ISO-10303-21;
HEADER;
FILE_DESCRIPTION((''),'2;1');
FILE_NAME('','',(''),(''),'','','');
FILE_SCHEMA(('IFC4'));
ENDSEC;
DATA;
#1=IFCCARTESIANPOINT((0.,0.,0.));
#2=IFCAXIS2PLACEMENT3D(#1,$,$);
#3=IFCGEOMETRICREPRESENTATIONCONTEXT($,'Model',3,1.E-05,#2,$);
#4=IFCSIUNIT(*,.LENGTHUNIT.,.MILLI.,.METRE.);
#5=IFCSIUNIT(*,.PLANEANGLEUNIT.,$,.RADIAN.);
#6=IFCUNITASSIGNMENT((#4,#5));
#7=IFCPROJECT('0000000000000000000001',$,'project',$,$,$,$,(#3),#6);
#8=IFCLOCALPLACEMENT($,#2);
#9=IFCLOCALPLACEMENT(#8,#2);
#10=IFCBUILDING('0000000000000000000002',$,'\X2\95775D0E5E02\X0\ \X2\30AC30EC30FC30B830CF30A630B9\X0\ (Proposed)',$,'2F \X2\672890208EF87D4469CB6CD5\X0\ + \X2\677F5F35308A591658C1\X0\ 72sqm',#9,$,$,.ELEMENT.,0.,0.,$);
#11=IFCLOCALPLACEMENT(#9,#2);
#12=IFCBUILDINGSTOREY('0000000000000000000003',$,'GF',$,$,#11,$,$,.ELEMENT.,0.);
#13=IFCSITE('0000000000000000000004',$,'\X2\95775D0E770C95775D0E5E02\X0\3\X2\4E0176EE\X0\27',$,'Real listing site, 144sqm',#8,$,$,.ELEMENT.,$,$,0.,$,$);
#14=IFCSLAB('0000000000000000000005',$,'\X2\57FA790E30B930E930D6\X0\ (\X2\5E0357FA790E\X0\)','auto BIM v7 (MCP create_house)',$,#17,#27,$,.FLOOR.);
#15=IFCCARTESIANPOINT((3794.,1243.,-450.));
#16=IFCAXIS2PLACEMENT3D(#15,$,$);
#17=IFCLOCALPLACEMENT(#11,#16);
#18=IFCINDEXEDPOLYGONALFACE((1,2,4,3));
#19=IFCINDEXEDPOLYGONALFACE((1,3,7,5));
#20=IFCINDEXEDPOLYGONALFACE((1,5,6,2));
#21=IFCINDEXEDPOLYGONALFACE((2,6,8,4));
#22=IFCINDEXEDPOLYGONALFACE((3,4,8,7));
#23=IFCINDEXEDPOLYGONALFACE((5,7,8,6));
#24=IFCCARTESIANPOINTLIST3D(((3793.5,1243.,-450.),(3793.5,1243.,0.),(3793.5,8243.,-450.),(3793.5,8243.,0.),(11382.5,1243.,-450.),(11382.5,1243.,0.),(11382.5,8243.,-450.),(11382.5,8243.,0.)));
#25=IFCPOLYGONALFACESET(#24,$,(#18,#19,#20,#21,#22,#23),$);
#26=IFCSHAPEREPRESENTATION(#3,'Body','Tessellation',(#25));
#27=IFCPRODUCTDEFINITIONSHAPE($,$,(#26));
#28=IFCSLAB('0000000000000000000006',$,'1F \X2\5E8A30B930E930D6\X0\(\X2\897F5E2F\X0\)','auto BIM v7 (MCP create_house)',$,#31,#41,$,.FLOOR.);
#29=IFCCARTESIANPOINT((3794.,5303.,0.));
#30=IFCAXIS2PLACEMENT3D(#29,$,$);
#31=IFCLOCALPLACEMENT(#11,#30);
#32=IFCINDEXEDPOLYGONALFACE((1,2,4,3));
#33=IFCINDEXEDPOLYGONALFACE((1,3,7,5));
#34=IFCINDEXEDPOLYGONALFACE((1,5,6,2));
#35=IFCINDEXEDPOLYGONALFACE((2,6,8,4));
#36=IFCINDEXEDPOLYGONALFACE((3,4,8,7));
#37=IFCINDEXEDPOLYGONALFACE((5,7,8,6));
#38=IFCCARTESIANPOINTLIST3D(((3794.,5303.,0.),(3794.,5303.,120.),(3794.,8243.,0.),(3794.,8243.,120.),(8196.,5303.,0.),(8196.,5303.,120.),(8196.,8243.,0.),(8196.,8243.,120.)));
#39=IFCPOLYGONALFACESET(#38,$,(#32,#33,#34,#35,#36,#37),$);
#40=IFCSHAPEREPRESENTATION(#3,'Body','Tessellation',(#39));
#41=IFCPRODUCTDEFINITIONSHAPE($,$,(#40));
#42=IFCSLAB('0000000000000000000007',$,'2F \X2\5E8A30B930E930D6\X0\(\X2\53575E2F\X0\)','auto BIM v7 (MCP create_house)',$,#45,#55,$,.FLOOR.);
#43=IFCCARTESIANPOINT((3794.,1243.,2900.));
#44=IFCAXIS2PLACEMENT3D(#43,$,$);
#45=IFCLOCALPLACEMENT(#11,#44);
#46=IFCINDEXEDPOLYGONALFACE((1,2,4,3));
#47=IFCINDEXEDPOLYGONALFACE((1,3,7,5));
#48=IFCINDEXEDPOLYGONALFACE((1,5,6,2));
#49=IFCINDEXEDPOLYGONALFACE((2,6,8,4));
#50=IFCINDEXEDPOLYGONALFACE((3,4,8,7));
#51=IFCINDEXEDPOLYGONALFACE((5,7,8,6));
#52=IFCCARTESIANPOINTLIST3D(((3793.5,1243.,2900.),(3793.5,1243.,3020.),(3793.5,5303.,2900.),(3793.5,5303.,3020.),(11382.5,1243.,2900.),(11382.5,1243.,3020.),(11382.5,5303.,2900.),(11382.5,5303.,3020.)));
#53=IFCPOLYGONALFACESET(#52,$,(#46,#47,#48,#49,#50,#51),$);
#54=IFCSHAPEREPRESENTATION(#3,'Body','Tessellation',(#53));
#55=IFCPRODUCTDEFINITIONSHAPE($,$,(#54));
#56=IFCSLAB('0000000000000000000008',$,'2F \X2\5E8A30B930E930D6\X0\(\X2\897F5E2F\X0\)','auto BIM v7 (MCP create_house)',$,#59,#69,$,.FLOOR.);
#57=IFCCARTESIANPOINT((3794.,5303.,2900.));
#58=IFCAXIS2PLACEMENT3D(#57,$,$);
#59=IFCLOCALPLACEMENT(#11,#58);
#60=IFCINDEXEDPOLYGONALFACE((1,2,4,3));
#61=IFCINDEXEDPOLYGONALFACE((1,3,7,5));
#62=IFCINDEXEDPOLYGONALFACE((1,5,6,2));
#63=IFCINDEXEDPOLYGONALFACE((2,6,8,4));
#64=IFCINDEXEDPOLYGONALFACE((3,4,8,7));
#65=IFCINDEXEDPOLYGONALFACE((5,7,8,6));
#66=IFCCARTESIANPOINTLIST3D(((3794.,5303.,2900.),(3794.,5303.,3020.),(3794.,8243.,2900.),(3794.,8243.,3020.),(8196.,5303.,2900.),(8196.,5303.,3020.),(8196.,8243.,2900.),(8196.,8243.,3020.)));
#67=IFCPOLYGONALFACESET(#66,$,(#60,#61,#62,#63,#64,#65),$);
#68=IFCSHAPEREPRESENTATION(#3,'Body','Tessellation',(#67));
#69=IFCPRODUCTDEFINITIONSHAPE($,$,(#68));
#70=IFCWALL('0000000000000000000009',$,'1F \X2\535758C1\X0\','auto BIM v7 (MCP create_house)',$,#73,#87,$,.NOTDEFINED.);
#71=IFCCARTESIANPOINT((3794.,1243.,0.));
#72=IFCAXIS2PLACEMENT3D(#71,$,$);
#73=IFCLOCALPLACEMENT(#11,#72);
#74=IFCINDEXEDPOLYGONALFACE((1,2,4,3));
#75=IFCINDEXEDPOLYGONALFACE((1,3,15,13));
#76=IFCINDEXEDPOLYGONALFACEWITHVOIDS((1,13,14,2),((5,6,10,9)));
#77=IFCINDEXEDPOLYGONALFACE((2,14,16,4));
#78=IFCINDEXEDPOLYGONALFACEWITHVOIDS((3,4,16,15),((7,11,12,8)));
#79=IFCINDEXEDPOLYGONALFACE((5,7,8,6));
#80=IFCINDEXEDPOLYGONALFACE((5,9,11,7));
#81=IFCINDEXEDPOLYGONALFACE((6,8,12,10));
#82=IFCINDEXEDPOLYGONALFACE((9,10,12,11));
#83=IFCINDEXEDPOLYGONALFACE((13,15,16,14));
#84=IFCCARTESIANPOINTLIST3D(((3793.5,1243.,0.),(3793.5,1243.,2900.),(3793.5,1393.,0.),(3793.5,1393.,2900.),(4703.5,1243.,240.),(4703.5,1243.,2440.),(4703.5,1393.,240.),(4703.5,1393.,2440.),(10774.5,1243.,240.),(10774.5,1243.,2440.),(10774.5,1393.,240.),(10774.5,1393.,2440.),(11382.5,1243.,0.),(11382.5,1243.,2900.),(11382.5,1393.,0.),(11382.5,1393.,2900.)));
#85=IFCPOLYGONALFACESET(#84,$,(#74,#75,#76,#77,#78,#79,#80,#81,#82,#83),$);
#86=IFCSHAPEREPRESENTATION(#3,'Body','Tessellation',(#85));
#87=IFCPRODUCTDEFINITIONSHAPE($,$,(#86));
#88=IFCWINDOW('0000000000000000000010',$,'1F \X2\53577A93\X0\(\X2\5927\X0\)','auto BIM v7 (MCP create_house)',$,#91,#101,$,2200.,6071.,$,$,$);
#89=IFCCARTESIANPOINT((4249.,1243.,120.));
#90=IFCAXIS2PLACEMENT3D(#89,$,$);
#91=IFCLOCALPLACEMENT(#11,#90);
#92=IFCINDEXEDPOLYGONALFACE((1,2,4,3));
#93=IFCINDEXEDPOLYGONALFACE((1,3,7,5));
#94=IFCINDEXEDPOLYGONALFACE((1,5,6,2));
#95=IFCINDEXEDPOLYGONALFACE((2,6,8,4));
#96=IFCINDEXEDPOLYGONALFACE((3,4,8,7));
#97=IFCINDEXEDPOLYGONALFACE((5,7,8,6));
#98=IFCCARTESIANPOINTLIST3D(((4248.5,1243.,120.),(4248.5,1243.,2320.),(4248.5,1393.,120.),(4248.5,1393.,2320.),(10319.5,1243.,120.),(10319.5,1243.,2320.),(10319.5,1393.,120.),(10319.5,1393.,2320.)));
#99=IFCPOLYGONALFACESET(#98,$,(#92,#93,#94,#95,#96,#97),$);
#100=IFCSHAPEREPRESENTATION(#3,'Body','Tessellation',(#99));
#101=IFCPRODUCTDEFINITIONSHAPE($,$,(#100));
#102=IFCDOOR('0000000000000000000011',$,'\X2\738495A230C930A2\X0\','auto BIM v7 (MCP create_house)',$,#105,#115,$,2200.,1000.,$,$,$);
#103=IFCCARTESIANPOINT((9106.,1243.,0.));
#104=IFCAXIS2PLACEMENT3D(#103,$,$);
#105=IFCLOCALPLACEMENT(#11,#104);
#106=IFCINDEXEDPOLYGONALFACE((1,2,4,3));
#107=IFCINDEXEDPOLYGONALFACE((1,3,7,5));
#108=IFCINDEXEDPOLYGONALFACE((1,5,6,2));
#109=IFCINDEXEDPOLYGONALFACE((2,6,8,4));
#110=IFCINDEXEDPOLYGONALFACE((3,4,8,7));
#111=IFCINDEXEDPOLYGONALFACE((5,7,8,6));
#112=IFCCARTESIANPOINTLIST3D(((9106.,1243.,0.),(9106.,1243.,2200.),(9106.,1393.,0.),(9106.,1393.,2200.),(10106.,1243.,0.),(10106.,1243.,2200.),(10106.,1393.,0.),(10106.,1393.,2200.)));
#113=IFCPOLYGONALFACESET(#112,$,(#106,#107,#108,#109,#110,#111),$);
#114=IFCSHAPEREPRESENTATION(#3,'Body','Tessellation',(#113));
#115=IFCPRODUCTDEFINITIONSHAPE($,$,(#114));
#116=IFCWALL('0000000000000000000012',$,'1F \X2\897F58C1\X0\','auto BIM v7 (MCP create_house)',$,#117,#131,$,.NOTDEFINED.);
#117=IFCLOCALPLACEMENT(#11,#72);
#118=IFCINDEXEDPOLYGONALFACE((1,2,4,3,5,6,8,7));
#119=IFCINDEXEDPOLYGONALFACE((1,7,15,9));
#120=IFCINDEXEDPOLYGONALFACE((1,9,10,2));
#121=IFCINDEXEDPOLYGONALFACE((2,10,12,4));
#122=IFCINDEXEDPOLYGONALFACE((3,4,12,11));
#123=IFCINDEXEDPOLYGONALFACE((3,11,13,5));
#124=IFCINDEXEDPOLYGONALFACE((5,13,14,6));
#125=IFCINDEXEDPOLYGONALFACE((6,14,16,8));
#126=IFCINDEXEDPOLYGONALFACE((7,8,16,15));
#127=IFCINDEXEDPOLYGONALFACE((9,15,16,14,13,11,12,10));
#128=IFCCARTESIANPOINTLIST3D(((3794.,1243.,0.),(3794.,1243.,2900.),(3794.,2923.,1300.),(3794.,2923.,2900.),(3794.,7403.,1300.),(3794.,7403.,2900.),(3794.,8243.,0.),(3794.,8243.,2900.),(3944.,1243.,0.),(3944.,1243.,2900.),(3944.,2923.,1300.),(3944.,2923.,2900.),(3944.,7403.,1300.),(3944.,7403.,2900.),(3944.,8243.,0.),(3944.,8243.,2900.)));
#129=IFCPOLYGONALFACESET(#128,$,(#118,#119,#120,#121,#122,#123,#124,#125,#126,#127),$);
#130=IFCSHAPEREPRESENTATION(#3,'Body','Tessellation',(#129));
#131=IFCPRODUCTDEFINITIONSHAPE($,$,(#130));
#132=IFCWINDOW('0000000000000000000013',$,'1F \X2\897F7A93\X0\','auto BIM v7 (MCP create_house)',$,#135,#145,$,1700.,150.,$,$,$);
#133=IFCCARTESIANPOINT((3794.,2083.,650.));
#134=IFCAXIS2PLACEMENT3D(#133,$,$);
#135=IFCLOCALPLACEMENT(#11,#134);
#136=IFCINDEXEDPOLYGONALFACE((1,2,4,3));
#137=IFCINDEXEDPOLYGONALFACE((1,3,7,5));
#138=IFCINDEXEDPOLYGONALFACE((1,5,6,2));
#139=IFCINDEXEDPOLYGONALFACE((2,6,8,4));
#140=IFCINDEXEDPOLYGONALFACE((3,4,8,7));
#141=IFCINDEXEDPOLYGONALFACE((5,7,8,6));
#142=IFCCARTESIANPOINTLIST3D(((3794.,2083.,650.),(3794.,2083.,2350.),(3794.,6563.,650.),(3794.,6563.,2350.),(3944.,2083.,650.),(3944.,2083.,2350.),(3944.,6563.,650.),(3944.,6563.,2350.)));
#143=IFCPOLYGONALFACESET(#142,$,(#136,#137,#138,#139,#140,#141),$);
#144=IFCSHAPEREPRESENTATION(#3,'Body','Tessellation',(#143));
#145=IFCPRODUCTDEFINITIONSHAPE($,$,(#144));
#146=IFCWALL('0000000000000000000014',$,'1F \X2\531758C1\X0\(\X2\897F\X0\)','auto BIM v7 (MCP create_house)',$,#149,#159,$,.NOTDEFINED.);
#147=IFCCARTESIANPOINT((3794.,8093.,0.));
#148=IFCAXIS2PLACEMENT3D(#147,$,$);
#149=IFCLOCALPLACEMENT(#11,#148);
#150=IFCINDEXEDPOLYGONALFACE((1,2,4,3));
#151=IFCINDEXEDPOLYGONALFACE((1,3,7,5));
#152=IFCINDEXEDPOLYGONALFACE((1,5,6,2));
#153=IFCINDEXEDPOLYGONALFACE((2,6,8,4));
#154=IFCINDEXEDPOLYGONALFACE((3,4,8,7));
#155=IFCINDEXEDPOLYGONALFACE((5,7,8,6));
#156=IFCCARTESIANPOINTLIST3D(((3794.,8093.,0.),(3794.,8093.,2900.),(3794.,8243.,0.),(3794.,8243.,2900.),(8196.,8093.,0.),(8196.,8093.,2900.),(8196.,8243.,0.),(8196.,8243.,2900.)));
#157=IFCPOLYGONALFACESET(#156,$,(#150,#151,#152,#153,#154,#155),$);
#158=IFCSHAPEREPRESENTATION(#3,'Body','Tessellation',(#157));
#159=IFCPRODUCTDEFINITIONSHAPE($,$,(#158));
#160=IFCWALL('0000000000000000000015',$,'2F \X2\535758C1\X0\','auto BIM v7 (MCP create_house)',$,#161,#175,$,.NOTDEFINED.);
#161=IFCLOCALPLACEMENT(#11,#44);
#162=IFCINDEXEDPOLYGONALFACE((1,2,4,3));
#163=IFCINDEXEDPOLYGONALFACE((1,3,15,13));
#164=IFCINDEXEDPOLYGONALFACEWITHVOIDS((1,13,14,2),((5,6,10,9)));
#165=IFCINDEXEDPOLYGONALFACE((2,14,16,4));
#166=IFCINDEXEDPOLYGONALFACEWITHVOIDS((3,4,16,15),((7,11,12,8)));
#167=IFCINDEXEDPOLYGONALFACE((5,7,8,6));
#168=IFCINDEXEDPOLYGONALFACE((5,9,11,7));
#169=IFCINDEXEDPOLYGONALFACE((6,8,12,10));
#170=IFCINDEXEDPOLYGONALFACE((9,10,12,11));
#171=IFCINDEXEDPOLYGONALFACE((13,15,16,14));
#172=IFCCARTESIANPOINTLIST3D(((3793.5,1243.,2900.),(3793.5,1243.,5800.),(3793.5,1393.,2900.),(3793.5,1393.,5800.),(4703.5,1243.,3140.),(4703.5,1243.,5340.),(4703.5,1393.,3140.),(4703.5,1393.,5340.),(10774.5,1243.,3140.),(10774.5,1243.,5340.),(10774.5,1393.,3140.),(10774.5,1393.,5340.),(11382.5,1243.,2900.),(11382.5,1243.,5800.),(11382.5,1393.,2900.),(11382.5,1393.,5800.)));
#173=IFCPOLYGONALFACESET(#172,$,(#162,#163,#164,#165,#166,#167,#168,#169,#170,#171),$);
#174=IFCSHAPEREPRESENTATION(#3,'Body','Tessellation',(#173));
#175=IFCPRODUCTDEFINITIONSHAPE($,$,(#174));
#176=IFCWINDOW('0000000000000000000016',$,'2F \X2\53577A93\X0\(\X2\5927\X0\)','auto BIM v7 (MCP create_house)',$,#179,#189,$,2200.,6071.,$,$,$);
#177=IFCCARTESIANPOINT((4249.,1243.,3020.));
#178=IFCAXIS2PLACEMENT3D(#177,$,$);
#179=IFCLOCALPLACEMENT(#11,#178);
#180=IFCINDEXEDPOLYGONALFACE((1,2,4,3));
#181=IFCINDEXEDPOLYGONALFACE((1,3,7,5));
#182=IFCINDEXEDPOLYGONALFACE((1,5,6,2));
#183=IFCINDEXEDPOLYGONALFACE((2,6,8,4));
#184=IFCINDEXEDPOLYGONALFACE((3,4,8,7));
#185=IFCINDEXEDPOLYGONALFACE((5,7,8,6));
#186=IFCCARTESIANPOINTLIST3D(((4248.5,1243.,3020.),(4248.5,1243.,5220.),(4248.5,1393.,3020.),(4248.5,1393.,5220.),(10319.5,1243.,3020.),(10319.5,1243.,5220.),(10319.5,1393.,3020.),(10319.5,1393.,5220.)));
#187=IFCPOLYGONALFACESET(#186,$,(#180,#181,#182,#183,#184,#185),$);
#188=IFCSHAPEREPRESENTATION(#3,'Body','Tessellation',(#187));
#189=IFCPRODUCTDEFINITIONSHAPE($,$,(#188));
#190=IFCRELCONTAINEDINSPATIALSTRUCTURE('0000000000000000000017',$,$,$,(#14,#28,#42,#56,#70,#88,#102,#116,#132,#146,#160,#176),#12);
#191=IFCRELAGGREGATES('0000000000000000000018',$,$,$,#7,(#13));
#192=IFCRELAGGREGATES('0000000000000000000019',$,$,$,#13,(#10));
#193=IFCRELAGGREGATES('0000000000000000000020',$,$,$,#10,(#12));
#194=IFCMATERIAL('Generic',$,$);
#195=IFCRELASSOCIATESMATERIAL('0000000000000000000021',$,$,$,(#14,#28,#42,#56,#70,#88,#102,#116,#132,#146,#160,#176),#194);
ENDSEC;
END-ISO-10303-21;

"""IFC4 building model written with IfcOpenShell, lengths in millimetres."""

from ifc_helpers import new_model, si_unit, frame, frame_2d, origin, place, context, project, spatial, rectangle, extrude, material, element, fill, save


model = new_model("IFC4")

# Units and contexts
model_context = context("Model", 3, precision=1e-05, world=origin())
ifc_project = project(units=[si_unit("LENGTHUNIT", "METRE", prefix="MILLI"), si_unit("PLANEANGLEUNIT", "RADIAN")], contexts=[model_context])

# Site, building, storey
site_placement = place(None, origin())
site = spatial("IfcSite", under=ifc_project, at=site_placement, Name="長崎県長崎市3丁目27", ObjectType="Real listing site, 144sqm", CompositionType="ELEMENT", RefElevation=0.0)
building_placement = place(site_placement, origin())
building = spatial("IfcBuilding", under=site, at=building_placement, Name="長崎市 ガレージハウス (Proposed)", ObjectType="2F 木造軸組構法 + 板張り外壁 72sqm", CompositionType="ELEMENT", ElevationOfRefHeight=0.0, ElevationOfTerrain=0.0)
storey_placement = place(building_placement, origin())
storey = spatial("IfcBuildingStorey", under=building, at=storey_placement, Name="GF", CompositionType="ELEMENT", Elevation=0.0)

# Slabs
ifc_material = material(Name="Generic")
slab_1_placement = place(storey_placement, frame((3794.0, 1243.0, -450.0)))
element("IfcSlab", 1, at=slab_1_placement, inside=storey, material=ifc_material, Name="基礎スラブ (布基礎)", Description="auto BIM v7 (MCP create_house)", PredefinedType="FLOOR", context=model_context, shape_type="SweptSolid", body=[
    extrude(rectangle(XDim=7589.0, YDim=7000.0, at=frame_2d((3794.0, 3500.0))), frame((3794.0, 1243.0, -450.0)), (0.0, 0.0, 1.0), 450.0),
])
slab_2_placement = place(storey_placement, frame((3794.0, 5303.0, 0.0)))
element("IfcSlab", 2, at=slab_2_placement, inside=storey, material=ifc_material, Name="1F 床スラブ(西帯)", Description="auto BIM v7 (MCP create_house)", PredefinedType="FLOOR", context=model_context, shape_type="SweptSolid", body=[
    extrude(rectangle(XDim=4402.0, YDim=2940.0, at=frame_2d((2201.0, 1470.0))), frame((3794.0, 5303.0, 0.0)), (0.0, 0.0, 1.0), 120.0),
])
slab_3_placement = place(storey_placement, frame((3794.0, 1243.0, 2900.0)))
element("IfcSlab", 3, at=slab_3_placement, inside=storey, material=ifc_material, Name="2F 床スラブ(南帯)", Description="auto BIM v7 (MCP create_house)", PredefinedType="FLOOR", context=model_context, shape_type="SweptSolid", body=[
    extrude(rectangle(XDim=7589.0, YDim=4060.0, at=frame_2d((3794.0, 2030.0))), frame((3794.0, 1243.0, 2900.0)), (0.0, 0.0, 1.0), 120.0),
])
slab_4_placement = place(storey_placement, frame((3794.0, 5303.0, 2900.0)))
element("IfcSlab", 4, at=slab_4_placement, inside=storey, material=ifc_material, Name="2F 床スラブ(西帯)", Description="auto BIM v7 (MCP create_house)", PredefinedType="FLOOR", context=model_context, shape_type="SweptSolid", body=[
    extrude(rectangle(XDim=4402.0, YDim=2940.0, at=frame_2d((2201.0, 1470.0))), frame((3794.0, 5303.0, 2900.0)), (0.0, 0.0, 1.0), 120.0),
])

# Wall, openings, window, door
wall_1_placement = place(storey_placement, frame((3794.0, 1243.0, 0.0)))
wall_1 = element("IfcWall", 5, at=wall_1_placement, inside=storey, material=ifc_material, Name="1F 南壁", Description="auto BIM v7 (MCP create_house)", PredefinedType="NOTDEFINED", context=model_context, shape_type="SweptSolid", body=[
    extrude(rectangle(XDim=7589.0, YDim=150.0, at=frame_2d((3794.0, 75.0))), frame((3794.0, 1243.0, 0.0)), (0.0, 0.0, 1.0), 2900.0),
])
opening_1_placement = place(storey_placement, frame((4249.0, 1243.0, 120.0)))
opening_1 = element("IfcOpeningElement", 6, at=opening_1_placement, cuts=wall_1, PredefinedType="NOTDEFINED", context=model_context, shape_type="SweptSolid", body=[
    extrude(rectangle(XDim=6071.0, YDim=150.0, at=frame_2d((3035.0, 75.0))), frame((4249.0, 1243.0, 120.0)), (0.0, 0.0, 1.0), 2200.0),
])
opening_2_placement = place(storey_placement, frame((9106.0, 1243.0, 0.0)))
opening_2 = element("IfcOpeningElement", 7, at=opening_2_placement, cuts=wall_1, PredefinedType="NOTDEFINED", context=model_context, shape_type="SweptSolid", body=[
    extrude(rectangle(XDim=1000.0, YDim=150.0, at=frame_2d((500.0, 75.0))), frame((9106.0, 1243.0, 0.0)), (0.0, 0.0, 1.0), 2200.0),
])
window_1_placement = place(storey_placement, frame((4249.0, 1243.0, 120.0)))
window_1 = element("IfcWindow", 8, at=window_1_placement, inside=storey, material=ifc_material, Name="1F 南窓(大)", Description="auto BIM v7 (MCP create_house)", OverallHeight=2200.0, OverallWidth=6071.0, context=model_context, shape_type="SweptSolid", body=[
    extrude(rectangle(XDim=6071.0, YDim=150.0, at=frame_2d((3035.0, 75.0))), frame((4249.0, 1243.0, 120.0)), (0.0, 0.0, 1.0), 2200.0),
])
fill(opening_1, window_1)
door_placement = place(storey_placement, frame((9106.0, 1243.0, 0.0)))
door = element("IfcDoor", 9, at=door_placement, inside=storey, material=ifc_material, Name="玄関ドア", Description="auto BIM v7 (MCP create_house)", OverallHeight=2200.0, OverallWidth=1000.0, context=model_context, shape_type="SweptSolid", body=[
    extrude(rectangle(XDim=1000.0, YDim=150.0, at=frame_2d((500.0, 75.0))), frame((9106.0, 1243.0, 0.0)), (0.0, 0.0, 1.0), 2200.0),
])
fill(opening_2, door)

# Wall, opening, window
wall_2_placement = place(storey_placement, frame((3794.0, 1243.0, 0.0)))
wall_2 = element("IfcWall", 10, at=wall_2_placement, inside=storey, material=ifc_material, Name="1F 西壁", Description="auto BIM v7 (MCP create_house)", PredefinedType="NOTDEFINED", context=model_context, shape_type="SweptSolid", body=[
    extrude(rectangle(XDim=150.0, YDim=7000.0, at=frame_2d((75.0, 3500.0))), frame((3794.0, 1243.0, 0.0)), (0.0, 0.0, 1.0), 2900.0),
])
opening_3_placement = place(storey_placement, frame((3794.0, 2083.0, 650.0)))
opening_3 = element("IfcOpeningElement", 11, at=opening_3_placement, cuts=wall_2, PredefinedType="NOTDEFINED", context=model_context, shape_type="SweptSolid", body=[
    extrude(rectangle(XDim=150.0, YDim=4480.0, at=frame_2d((75.0, 2240.0))), frame((3794.0, 2083.0, 650.0)), (0.0, 0.0, 1.0), 1700.0),
])
window_2_placement = place(storey_placement, frame((3794.0, 2083.0, 650.0)))
window_2 = element("IfcWindow", 12, at=window_2_placement, inside=storey, material=ifc_material, Name="1F 西窓", Description="auto BIM v7 (MCP create_house)", OverallHeight=1700.0, OverallWidth=150.0, context=model_context, shape_type="SweptSolid", body=[
    extrude(rectangle(XDim=150.0, YDim=4480.0, at=frame_2d((75.0, 2240.0))), frame((3794.0, 2083.0, 650.0)), (0.0, 0.0, 1.0), 1700.0),
])
fill(opening_3, window_2)

# Wall
wall_3_placement = place(storey_placement, frame((3794.0, 8093.0, 0.0)))
element("IfcWall", 13, at=wall_3_placement, inside=storey, material=ifc_material, Name="1F 北壁(西)", Description="auto BIM v7 (MCP create_house)", PredefinedType="NOTDEFINED", context=model_context, shape_type="SweptSolid", body=[
    extrude(rectangle(XDim=4402.0, YDim=150.0, at=frame_2d((2201.0, 75.0))), frame((3794.0, 8093.0, 0.0)), (0.0, 0.0, 1.0), 2900.0),
])

# Wall, opening, window
wall_4_placement = place(storey_placement, frame((3794.0, 1243.0, 2900.0)))
wall_4 = element("IfcWall", 14, at=wall_4_placement, inside=storey, material=ifc_material, Name="2F 南壁", Description="auto BIM v7 (MCP create_house)", PredefinedType="NOTDEFINED", context=model_context, shape_type="SweptSolid", body=[
    extrude(rectangle(XDim=7589.0, YDim=150.0, at=frame_2d((3794.0, 75.0))), frame((3794.0, 1243.0, 2900.0)), (0.0, 0.0, 1.0), 2900.0),
])
opening_4_placement = place(storey_placement, frame((4249.0, 1243.0, 3020.0)))
opening_4 = element("IfcOpeningElement", 15, at=opening_4_placement, cuts=wall_4, PredefinedType="NOTDEFINED", context=model_context, shape_type="SweptSolid", body=[
    extrude(rectangle(XDim=6071.0, YDim=150.0, at=frame_2d((3035.0, 75.0))), frame((4249.0, 1243.0, 3020.0)), (0.0, 0.0, 1.0), 2200.0),
])
window_3_placement = place(storey_placement, frame((4249.0, 1243.0, 3020.0)))
window_3 = element("IfcWindow", 16, at=window_3_placement, inside=storey, material=ifc_material, Name="2F 南窓(大)", Description="auto BIM v7 (MCP create_house)", OverallHeight=2200.0, OverallWidth=6071.0, context=model_context, shape_type="SweptSolid", body=[
    extrude(rectangle(XDim=6071.0, YDim=150.0, at=frame_2d((3035.0, 75.0))), frame((4249.0, 1243.0, 3020.0)), (0.0, 0.0, 1.0), 2200.0),
])
fill(opening_4, window_3)

save(model, "model.ifc")
